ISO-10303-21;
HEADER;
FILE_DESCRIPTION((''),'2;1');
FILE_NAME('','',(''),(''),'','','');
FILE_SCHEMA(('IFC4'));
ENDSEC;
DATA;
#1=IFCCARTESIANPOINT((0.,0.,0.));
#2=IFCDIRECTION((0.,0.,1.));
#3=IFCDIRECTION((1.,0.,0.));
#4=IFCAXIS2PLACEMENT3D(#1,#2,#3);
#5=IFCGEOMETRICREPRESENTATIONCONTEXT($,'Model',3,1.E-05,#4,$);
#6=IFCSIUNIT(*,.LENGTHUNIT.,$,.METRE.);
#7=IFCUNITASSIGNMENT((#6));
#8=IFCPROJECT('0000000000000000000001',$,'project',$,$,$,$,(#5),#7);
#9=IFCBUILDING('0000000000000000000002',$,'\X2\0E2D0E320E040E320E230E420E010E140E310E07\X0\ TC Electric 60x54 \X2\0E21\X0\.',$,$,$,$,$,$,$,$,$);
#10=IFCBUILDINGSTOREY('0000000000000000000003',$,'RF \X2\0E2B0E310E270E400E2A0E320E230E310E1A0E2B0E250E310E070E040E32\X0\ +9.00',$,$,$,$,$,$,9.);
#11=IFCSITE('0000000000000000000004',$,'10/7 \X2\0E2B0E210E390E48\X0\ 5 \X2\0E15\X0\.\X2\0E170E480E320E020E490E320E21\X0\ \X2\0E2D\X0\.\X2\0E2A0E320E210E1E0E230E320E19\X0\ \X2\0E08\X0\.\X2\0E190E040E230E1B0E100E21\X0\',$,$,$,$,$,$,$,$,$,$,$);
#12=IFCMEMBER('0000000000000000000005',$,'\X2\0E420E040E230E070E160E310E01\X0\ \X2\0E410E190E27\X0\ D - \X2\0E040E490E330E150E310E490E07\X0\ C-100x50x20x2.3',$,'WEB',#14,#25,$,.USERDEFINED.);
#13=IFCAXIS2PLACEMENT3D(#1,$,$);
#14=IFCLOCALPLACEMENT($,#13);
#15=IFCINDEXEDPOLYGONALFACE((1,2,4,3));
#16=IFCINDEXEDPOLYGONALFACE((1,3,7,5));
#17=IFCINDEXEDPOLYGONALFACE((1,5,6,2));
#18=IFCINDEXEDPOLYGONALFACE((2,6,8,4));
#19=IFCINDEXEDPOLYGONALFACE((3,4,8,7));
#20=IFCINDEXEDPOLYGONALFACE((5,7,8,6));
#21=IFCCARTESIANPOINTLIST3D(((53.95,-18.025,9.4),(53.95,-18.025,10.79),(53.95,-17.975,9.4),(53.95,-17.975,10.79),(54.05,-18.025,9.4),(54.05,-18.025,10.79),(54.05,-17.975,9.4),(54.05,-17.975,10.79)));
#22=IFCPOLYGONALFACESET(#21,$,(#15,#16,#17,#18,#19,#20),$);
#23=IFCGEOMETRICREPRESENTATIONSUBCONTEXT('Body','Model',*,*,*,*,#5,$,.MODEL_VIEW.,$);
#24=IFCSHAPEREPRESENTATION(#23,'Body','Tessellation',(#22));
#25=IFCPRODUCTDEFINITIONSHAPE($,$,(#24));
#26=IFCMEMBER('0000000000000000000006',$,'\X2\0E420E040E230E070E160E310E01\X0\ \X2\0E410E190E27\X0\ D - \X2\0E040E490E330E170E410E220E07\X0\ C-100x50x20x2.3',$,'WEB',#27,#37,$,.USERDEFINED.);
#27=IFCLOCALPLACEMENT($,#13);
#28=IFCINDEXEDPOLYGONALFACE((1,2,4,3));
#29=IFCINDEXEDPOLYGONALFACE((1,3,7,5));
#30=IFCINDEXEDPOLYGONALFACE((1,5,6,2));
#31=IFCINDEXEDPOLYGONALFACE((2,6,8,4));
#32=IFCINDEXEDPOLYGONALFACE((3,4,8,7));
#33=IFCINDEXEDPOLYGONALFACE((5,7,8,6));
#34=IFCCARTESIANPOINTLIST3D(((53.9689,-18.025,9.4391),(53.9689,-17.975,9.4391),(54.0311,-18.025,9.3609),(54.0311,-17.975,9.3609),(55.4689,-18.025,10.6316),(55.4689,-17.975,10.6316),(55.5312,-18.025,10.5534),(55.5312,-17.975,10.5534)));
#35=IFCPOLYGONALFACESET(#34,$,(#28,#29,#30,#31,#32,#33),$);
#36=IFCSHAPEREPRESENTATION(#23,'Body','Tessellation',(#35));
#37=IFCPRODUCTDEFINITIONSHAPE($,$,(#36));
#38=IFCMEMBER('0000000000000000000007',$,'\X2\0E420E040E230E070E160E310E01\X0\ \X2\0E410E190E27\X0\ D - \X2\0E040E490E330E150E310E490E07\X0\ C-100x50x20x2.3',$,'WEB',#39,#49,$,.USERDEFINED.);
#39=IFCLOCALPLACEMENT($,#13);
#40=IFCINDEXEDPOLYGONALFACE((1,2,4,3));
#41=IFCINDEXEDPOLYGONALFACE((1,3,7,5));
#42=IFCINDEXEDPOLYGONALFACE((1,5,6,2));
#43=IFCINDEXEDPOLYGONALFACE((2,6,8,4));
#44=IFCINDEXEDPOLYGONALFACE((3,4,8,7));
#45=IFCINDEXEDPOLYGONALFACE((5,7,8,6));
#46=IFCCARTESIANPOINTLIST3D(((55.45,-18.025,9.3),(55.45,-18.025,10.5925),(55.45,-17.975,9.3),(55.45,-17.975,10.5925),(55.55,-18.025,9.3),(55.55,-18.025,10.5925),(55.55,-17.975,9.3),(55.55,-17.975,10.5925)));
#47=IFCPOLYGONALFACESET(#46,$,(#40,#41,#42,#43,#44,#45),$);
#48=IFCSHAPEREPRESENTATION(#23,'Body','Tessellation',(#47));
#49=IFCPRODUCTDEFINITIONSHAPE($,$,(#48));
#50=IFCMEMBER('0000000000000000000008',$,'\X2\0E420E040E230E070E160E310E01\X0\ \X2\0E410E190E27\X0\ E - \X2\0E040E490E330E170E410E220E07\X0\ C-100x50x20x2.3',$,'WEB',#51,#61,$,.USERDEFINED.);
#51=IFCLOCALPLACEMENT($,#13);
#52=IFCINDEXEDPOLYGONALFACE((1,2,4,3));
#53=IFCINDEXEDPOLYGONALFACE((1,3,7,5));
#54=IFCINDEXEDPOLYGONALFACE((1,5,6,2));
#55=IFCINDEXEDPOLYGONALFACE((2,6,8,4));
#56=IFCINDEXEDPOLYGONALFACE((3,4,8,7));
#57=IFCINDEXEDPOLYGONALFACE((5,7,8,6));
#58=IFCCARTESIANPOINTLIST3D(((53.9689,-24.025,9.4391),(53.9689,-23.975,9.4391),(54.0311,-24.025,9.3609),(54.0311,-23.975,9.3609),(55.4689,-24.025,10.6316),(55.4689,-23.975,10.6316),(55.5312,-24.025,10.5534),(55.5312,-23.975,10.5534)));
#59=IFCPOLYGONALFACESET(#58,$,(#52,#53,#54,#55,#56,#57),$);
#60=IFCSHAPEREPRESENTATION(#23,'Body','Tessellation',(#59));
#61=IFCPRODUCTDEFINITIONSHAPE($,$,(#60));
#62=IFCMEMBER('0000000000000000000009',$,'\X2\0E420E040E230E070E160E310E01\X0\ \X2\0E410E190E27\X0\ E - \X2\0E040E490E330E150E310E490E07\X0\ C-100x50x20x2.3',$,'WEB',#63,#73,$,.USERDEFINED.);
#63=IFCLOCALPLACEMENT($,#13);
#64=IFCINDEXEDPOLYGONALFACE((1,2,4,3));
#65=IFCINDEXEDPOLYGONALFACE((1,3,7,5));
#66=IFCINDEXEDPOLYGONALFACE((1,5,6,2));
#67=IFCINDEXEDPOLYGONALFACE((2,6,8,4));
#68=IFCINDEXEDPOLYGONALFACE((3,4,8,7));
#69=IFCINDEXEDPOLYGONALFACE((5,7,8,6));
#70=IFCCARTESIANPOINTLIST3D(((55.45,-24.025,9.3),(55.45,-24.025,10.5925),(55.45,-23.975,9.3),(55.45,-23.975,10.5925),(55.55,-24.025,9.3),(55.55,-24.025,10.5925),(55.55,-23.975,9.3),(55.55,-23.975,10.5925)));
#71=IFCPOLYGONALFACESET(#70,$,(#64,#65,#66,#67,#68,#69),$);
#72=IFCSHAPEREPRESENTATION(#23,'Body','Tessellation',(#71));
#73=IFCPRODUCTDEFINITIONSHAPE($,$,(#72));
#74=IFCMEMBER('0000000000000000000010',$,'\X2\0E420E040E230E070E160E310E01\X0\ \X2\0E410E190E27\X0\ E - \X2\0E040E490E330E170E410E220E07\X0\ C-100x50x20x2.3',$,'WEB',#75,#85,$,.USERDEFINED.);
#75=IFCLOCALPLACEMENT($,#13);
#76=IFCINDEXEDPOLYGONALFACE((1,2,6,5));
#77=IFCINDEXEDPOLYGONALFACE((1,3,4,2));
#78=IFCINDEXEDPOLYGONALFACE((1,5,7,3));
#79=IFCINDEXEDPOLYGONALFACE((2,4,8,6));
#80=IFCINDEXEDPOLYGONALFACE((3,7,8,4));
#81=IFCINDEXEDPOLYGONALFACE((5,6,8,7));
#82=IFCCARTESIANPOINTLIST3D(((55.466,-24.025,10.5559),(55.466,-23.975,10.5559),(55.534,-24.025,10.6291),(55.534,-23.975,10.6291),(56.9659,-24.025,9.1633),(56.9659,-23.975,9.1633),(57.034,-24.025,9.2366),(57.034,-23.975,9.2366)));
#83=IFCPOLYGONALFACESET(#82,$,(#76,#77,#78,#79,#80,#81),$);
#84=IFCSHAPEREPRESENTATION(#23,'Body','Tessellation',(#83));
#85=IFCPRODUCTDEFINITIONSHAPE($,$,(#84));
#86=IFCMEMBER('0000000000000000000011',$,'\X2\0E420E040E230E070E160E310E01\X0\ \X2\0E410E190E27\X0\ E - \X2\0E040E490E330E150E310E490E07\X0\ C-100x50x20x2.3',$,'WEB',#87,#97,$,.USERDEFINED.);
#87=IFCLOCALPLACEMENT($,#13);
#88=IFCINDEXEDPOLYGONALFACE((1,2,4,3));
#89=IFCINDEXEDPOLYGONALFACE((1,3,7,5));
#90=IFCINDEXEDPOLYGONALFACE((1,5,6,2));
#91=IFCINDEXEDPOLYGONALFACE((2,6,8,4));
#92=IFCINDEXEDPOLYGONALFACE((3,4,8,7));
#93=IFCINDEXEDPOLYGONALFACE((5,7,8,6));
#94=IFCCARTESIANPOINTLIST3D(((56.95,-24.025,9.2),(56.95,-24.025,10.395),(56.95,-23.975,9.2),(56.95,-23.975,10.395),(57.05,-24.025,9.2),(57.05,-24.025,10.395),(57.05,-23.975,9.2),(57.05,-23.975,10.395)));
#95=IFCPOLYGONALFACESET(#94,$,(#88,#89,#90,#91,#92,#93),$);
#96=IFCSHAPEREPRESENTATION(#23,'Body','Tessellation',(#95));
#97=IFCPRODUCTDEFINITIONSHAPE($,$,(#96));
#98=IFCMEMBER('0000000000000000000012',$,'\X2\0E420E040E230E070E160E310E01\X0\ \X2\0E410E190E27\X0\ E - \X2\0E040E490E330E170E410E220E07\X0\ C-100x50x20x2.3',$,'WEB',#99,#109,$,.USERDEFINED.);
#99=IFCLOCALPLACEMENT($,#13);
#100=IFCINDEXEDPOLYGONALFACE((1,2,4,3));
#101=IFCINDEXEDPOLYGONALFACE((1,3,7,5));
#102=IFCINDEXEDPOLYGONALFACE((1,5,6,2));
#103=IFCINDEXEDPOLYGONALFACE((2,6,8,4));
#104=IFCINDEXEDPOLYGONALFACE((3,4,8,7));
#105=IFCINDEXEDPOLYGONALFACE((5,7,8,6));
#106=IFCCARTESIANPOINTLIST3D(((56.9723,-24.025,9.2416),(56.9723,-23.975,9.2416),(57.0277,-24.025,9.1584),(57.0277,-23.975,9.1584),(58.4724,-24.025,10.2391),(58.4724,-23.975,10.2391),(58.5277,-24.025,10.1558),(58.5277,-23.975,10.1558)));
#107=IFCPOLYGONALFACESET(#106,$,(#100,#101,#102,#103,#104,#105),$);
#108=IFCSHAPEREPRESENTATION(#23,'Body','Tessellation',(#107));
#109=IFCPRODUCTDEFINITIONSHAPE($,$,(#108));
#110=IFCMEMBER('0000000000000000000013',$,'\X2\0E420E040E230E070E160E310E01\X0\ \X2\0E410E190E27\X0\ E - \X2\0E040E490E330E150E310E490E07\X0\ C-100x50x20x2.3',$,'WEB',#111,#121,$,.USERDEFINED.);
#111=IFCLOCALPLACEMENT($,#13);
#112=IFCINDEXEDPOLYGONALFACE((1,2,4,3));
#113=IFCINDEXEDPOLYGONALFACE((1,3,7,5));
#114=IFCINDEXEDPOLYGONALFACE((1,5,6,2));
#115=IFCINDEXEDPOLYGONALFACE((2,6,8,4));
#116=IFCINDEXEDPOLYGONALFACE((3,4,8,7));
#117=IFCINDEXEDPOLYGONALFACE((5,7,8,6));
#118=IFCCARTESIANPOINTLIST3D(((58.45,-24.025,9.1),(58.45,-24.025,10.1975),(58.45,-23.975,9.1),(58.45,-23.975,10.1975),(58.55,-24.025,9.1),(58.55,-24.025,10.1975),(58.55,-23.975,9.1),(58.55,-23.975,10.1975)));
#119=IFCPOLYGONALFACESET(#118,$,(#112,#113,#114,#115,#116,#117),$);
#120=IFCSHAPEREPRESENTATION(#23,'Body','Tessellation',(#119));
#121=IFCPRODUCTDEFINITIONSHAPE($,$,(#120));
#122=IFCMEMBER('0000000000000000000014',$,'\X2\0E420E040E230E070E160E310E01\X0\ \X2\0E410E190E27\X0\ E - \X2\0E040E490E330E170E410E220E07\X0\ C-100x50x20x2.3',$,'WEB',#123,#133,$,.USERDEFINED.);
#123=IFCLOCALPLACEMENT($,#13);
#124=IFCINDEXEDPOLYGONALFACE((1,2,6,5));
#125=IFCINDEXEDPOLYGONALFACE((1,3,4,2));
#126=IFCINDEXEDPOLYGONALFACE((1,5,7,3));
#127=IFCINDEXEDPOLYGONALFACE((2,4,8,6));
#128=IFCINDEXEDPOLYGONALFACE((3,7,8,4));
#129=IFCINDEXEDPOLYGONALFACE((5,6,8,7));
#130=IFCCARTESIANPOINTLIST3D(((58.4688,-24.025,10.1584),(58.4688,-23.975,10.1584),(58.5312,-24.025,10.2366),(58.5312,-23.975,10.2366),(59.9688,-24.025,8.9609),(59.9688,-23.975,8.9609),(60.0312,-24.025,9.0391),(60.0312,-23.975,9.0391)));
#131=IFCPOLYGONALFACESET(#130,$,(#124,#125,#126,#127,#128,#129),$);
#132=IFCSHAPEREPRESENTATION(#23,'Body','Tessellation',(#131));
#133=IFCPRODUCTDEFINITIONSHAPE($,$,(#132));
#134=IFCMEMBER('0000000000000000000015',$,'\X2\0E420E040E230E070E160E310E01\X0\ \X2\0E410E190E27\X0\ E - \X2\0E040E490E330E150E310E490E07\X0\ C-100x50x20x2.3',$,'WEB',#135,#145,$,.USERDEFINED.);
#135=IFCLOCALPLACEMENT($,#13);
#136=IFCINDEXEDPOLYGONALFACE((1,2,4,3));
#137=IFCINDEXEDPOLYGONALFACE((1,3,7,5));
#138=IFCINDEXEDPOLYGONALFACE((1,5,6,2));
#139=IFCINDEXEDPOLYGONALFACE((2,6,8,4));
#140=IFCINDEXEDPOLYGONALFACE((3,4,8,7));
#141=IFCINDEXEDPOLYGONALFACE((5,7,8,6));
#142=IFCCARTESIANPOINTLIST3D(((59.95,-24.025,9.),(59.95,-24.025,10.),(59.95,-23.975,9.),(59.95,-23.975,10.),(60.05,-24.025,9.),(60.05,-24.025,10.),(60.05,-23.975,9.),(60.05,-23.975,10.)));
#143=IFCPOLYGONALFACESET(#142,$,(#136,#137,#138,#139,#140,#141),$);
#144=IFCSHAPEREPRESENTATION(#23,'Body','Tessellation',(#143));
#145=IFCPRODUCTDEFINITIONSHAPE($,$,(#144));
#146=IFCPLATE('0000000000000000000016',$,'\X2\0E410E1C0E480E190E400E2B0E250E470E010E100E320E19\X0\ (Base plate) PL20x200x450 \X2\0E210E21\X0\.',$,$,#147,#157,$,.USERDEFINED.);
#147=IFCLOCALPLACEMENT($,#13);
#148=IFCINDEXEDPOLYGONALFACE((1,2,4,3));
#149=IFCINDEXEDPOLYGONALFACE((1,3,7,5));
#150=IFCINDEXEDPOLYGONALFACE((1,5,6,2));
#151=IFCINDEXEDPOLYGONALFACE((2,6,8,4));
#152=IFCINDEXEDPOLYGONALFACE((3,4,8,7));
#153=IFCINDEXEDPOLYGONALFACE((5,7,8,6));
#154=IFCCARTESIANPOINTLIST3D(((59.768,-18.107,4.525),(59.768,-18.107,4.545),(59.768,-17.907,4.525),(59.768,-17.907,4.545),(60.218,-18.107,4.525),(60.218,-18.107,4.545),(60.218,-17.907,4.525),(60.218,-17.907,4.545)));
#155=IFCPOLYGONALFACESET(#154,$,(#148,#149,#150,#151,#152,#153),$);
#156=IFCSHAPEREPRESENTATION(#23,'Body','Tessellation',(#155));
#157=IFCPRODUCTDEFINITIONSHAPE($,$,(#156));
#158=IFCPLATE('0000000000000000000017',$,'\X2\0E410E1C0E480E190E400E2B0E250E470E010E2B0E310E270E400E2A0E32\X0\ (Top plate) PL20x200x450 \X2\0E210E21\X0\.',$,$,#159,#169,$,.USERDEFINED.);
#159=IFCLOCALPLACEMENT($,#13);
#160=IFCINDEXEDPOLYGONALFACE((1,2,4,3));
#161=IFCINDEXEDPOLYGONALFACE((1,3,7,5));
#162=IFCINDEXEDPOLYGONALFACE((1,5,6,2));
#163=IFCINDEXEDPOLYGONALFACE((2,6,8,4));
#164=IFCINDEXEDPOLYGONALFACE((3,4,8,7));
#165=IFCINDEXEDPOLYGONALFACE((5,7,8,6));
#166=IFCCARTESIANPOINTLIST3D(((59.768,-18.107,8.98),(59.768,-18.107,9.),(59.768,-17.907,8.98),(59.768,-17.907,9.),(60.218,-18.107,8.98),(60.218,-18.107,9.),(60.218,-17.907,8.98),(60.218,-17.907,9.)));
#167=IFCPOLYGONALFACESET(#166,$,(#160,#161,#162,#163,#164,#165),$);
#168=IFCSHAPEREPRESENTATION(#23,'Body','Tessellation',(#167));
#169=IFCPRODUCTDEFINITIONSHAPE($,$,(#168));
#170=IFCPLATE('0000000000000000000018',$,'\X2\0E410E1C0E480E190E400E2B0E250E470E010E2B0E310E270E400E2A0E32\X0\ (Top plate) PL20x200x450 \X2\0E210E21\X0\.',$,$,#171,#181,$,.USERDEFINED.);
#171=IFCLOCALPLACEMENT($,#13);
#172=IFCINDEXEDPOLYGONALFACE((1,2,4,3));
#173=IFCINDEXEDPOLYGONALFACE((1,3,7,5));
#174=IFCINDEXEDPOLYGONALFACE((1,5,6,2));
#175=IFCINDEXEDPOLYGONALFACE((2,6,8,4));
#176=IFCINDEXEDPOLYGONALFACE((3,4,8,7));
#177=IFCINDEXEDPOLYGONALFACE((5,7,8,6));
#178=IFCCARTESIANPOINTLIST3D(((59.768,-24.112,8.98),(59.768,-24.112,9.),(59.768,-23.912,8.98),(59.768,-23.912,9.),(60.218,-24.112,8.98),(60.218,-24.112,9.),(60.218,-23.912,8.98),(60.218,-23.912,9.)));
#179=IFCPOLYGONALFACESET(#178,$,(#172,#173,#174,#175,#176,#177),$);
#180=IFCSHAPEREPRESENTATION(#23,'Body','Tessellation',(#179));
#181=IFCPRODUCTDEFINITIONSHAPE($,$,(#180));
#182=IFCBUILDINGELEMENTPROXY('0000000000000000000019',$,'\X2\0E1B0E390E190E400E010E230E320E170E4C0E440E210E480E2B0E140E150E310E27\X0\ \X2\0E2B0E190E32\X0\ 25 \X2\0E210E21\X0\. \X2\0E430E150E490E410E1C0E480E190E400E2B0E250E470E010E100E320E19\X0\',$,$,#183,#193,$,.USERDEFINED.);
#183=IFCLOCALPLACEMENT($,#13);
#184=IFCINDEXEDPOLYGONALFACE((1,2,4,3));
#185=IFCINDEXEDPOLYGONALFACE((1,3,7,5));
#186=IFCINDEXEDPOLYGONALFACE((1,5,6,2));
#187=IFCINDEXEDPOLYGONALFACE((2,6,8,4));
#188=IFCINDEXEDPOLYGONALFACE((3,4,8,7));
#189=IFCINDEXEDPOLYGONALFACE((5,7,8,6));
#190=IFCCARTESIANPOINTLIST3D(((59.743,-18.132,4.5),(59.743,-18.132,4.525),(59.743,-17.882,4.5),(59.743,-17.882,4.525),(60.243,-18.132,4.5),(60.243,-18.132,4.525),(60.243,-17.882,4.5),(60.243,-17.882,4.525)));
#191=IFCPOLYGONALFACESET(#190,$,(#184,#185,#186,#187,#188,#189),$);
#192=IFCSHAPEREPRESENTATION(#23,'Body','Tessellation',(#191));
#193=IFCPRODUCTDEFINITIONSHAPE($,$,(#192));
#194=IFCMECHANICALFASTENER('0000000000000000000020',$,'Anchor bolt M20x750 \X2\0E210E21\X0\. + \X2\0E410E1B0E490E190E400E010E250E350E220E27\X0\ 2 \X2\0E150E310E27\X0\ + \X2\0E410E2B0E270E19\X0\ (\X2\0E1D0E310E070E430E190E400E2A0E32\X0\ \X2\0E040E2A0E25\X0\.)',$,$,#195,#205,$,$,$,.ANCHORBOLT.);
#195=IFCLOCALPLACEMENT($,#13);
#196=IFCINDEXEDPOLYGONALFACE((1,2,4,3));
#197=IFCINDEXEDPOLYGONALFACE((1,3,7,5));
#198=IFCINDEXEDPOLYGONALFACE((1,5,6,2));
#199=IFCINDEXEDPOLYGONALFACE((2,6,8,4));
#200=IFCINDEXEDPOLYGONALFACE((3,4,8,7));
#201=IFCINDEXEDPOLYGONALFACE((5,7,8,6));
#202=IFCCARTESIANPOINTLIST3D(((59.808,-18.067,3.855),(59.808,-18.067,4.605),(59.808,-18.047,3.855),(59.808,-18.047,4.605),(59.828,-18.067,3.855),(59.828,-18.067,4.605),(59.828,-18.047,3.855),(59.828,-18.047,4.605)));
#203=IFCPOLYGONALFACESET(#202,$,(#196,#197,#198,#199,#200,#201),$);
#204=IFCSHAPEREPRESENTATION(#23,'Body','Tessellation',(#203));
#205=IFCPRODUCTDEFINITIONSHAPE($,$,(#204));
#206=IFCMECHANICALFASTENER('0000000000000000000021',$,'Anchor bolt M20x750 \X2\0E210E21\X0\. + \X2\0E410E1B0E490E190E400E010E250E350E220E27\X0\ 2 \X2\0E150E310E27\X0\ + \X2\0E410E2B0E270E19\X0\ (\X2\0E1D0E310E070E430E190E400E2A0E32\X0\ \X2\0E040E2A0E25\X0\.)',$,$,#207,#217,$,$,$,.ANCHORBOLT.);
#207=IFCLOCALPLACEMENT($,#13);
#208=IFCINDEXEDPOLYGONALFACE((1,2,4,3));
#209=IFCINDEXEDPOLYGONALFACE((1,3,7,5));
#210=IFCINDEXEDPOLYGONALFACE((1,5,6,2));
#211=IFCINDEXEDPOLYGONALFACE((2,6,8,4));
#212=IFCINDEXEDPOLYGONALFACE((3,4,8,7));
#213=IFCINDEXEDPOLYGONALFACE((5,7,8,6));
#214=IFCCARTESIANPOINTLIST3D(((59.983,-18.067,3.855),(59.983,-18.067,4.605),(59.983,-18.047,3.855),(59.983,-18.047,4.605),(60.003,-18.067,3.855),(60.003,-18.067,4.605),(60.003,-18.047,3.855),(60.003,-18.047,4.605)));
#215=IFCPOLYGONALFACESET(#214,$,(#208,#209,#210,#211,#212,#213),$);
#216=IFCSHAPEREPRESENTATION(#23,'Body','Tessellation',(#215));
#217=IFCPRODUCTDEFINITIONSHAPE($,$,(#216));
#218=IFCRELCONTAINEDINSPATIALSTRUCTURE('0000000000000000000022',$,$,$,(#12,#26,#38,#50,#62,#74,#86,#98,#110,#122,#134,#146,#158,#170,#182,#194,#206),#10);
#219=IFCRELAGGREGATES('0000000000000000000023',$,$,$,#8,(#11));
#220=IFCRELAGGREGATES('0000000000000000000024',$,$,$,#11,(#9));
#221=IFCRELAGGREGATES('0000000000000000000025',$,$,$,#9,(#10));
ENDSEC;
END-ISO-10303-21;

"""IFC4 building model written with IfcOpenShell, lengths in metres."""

from ifc_helpers import new_model, si_unit, frame, origin, origin_with_axes, origin_2d, place, context, subcontext, project, spatial, rectangle, extrude, element, save


model = new_model("IFC4")

# Units and contexts
model_context = context("Model", 3, precision=1e-05, world=origin_with_axes())
body_context = subcontext(model_context, "Body", "Model", "MODEL_VIEW")
ifc_project = project(units=[si_unit("LENGTHUNIT", "METRE")], contexts=[model_context])

# Site, building, storey
site = spatial("IfcSite", under=ifc_project, Name="10/7 หมู่ 5 ต.ท่าข้าม อ.สามพราน จ.นครปฐม")
building = spatial("IfcBuilding", under=site, Name="อาคารโกดัง TC Electric 60x54 ม.")
storey = spatial("IfcBuildingStorey", under=building, Name="RF หัวเสารับหลังคา +9.00", Elevation=9.0)

# Members
member_1_placement = place(None, frame((54.0, -18.0, 9.4), z_axis=(0.0, 0.0, 1.0), x_axis=(0.0, 1.0, 0.0)))
element("IfcMember", 1, at=member_1_placement, inside=storey, Name="โครงถัก แนว D - ค้ำตั้ง C-100x50x20x2.3", ObjectType="WEB", PredefinedType="USERDEFINED", context=body_context, shape_type="SweptSolid", body=[
    extrude(rectangle(XDim=0.05, YDim=0.1, at=origin_2d()), origin(), (0.0, 0.0, 1.0), 1.39),
])
member_2_placement = place(None, frame((54.0, -18.0, 9.4), z_axis=(0.7828, 0.0, 0.6223), x_axis=(0.0, -1.0, 0.0)))
element("IfcMember", 2, at=member_2_placement, inside=storey, Name="โครงถัก แนว D - ค้ำทแยง C-100x50x20x2.3", ObjectType="WEB", PredefinedType="USERDEFINED", context=body_context, shape_type="SweptSolid", body=[
    extrude(rectangle(XDim=0.05, YDim=0.1, at=origin_2d()), origin(), (0.0, 0.0, 1.0), 1.9163),
])
member_3_placement = place(None, frame((55.5, -18.0, 9.3), z_axis=(0.0, 0.0, 1.0), x_axis=(0.0, 1.0, 0.0)))
element("IfcMember", 3, at=member_3_placement, inside=storey, Name="โครงถัก แนว D - ค้ำตั้ง C-100x50x20x2.3", ObjectType="WEB", PredefinedType="USERDEFINED", context=body_context, shape_type="SweptSolid", body=[
    extrude(rectangle(XDim=0.05, YDim=0.1, at=origin_2d()), origin(), (0.0, 0.0, 1.0), 1.2925),
])
member_4_placement = place(None, frame((54.0, -24.0, 9.4), z_axis=(0.7828, 0.0, 0.6223), x_axis=(0.0, -1.0, 0.0)))
element("IfcMember", 4, at=member_4_placement, inside=storey, Name="โครงถัก แนว E - ค้ำทแยง C-100x50x20x2.3", ObjectType="WEB", PredefinedType="USERDEFINED", context=body_context, shape_type="SweptSolid", body=[
    extrude(rectangle(XDim=0.05, YDim=0.1, at=origin_2d()), origin(), (0.0, 0.0, 1.0), 1.9163),
])
member_5_placement = place(None, frame((55.5, -24.0, 9.3), z_axis=(0.0, 0.0, 1.0), x_axis=(0.0, 1.0, 0.0)))
element("IfcMember", 5, at=member_5_placement, inside=storey, Name="โครงถัก แนว E - ค้ำตั้ง C-100x50x20x2.3", ObjectType="WEB", PredefinedType="USERDEFINED", context=body_context, shape_type="SweptSolid", body=[
    extrude(rectangle(XDim=0.05, YDim=0.1, at=origin_2d()), origin(), (0.0, 0.0, 1.0), 1.2925),
])
member_6_placement = place(None, frame((55.5, -24.0, 10.5925), z_axis=(0.7329, 0.0, -0.6804), x_axis=(0.0, -1.0, 0.0)))
element("IfcMember", 6, at=member_6_placement, inside=storey, Name="โครงถัก แนว E - ค้ำทแยง C-100x50x20x2.3", ObjectType="WEB", PredefinedType="USERDEFINED", context=body_context, shape_type="SweptSolid", body=[
    extrude(rectangle(XDim=0.05, YDim=0.1, at=origin_2d()), origin(), (0.0, 0.0, 1.0), 2.0467),
])
member_7_placement = place(None, frame((57.0, -24.0, 9.2), z_axis=(0.0, 0.0, 1.0), x_axis=(0.0, 1.0, 0.0)))
element("IfcMember", 7, at=member_7_placement, inside=storey, Name="โครงถัก แนว E - ค้ำตั้ง C-100x50x20x2.3", ObjectType="WEB", PredefinedType="USERDEFINED", context=body_context, shape_type="SweptSolid", body=[
    extrude(rectangle(XDim=0.05, YDim=0.1, at=origin_2d()), origin(), (0.0, 0.0, 1.0), 1.195),
])
member_8_placement = place(None, frame((57.0, -24.0, 9.2), z_axis=(0.8327, 0.0, 0.5537), x_axis=(0.0, -1.0, 0.0)))
element("IfcMember", 8, at=member_8_placement, inside=storey, Name="โครงถัก แนว E - ค้ำทแยง C-100x50x20x2.3", ObjectType="WEB", PredefinedType="USERDEFINED", context=body_context, shape_type="SweptSolid", body=[
    extrude(rectangle(XDim=0.05, YDim=0.1, at=origin_2d()), origin(), (0.0, 0.0, 1.0), 1.8014),
])
member_9_placement = place(None, frame((58.5, -24.0, 9.1), z_axis=(0.0, 0.0, 1.0), x_axis=(0.0, 1.0, 0.0)))
element("IfcMember", 9, at=member_9_placement, inside=storey, Name="โครงถัก แนว E - ค้ำตั้ง C-100x50x20x2.3", ObjectType="WEB", PredefinedType="USERDEFINED", context=body_context, shape_type="SweptSolid", body=[
    extrude(rectangle(XDim=0.05, YDim=0.1, at=origin_2d()), origin(), (0.0, 0.0, 1.0), 1.0975),
])
member_10_placement = place(None, frame((58.5, -24.0, 10.1975), z_axis=(0.7815, 0.0, -0.6239), x_axis=(0.0, -1.0, 0.0)))
element("IfcMember", 10, at=member_10_placement, inside=storey, Name="โครงถัก แนว E - ค้ำทแยง C-100x50x20x2.3", ObjectType="WEB", PredefinedType="USERDEFINED", context=body_context, shape_type="SweptSolid", body=[
    extrude(rectangle(XDim=0.05, YDim=0.1, at=origin_2d()), origin(), (0.0, 0.0, 1.0), 1.9194),
])
member_11_placement = place(None, frame((60.0, -24.0, 9.0), z_axis=(0.0, 0.0, 1.0), x_axis=(0.0, 1.0, 0.0)))
element("IfcMember", 11, at=member_11_placement, inside=storey, Name="โครงถัก แนว E - ค้ำตั้ง C-100x50x20x2.3", ObjectType="WEB", PredefinedType="USERDEFINED", context=body_context, shape_type="SweptSolid", body=[
    extrude(rectangle(XDim=0.05, YDim=0.1, at=origin_2d()), origin(), (0.0, 0.0, 1.0), 1.0),
])

# Plates
for number, where, z_axis, x_axis, name in (
    (12, (59.993, -18.007, 4.525), (0.0, 0.0, 1.0), (1.0, 0.0, 0.0), "แผ่นเหล็กฐาน (Base plate) PL20x200x450 มม."),
    (13, (59.993, -18.007, 8.98), (0.0, 0.0, 1.0), (1.0, 0.0, 0.0), "แผ่นเหล็กหัวเสา (Top plate) PL20x200x450 มม."),
    (14, (59.993, -24.012, 8.98), (0.0, 0.0, 1.0), (1.0, 0.0, 0.0), "แผ่นเหล็กหัวเสา (Top plate) PL20x200x450 มม."),
):
    element("IfcPlate", number, at=place(None, frame(where, z_axis=z_axis, x_axis=x_axis)), inside=storey, Name=name, PredefinedType="USERDEFINED", context=body_context, shape_type="SweptSolid", body=[
        extrude(rectangle(XDim=0.45, YDim=0.2, at=origin_2d()), origin(), (0.0, 0.0, 1.0), 0.02),
    ])

# Building element proxy
proxy_1_placement = place(None, frame((59.993, -18.007, 4.5), z_axis=(0.0, 0.0, 1.0), x_axis=(1.0, 0.0, 0.0)))
element("IfcBuildingElementProxy", 15, at=proxy_1_placement, inside=storey, Name="ปูนเกราท์ไม่หดตัว หนา 25 มม. ใต้แผ่นเหล็กฐาน", PredefinedType="USERDEFINED", context=body_context, shape_type="SweptSolid", body=[
    extrude(rectangle(XDim=0.5, YDim=0.25, at=origin_2d()), origin(), (0.0, 0.0, 1.0), 0.025),
])

# Mechanical fasteners
for number, where, z_axis, x_axis, name in (
    (16, (59.818, -18.057, 3.855), (0.0, 0.0, 1.0), (1.0, 0.0, 0.0), "Anchor bolt M20x750 มม. + แป้นเกลียว 2 ตัว + แหวน (ฝังในเสา คสล.)"),
    (17, (59.993, -18.057, 3.855), (0.0, 0.0, 1.0), (1.0, 0.0, 0.0), "Anchor bolt M20x750 มม. + แป้นเกลียว 2 ตัว + แหวน (ฝังในเสา คสล.)"),
):
    element("IfcMechanicalFastener", number, at=place(None, frame(where, z_axis=z_axis, x_axis=x_axis)), inside=storey, Name=name, PredefinedType="ANCHORBOLT", context=body_context, shape_type="SweptSolid", body=[
        extrude(rectangle(XDim=0.02, YDim=0.02, at=origin_2d()), origin(), (0.0, 0.0, 1.0), 0.75),
    ])

save(model, "model.ifc")
